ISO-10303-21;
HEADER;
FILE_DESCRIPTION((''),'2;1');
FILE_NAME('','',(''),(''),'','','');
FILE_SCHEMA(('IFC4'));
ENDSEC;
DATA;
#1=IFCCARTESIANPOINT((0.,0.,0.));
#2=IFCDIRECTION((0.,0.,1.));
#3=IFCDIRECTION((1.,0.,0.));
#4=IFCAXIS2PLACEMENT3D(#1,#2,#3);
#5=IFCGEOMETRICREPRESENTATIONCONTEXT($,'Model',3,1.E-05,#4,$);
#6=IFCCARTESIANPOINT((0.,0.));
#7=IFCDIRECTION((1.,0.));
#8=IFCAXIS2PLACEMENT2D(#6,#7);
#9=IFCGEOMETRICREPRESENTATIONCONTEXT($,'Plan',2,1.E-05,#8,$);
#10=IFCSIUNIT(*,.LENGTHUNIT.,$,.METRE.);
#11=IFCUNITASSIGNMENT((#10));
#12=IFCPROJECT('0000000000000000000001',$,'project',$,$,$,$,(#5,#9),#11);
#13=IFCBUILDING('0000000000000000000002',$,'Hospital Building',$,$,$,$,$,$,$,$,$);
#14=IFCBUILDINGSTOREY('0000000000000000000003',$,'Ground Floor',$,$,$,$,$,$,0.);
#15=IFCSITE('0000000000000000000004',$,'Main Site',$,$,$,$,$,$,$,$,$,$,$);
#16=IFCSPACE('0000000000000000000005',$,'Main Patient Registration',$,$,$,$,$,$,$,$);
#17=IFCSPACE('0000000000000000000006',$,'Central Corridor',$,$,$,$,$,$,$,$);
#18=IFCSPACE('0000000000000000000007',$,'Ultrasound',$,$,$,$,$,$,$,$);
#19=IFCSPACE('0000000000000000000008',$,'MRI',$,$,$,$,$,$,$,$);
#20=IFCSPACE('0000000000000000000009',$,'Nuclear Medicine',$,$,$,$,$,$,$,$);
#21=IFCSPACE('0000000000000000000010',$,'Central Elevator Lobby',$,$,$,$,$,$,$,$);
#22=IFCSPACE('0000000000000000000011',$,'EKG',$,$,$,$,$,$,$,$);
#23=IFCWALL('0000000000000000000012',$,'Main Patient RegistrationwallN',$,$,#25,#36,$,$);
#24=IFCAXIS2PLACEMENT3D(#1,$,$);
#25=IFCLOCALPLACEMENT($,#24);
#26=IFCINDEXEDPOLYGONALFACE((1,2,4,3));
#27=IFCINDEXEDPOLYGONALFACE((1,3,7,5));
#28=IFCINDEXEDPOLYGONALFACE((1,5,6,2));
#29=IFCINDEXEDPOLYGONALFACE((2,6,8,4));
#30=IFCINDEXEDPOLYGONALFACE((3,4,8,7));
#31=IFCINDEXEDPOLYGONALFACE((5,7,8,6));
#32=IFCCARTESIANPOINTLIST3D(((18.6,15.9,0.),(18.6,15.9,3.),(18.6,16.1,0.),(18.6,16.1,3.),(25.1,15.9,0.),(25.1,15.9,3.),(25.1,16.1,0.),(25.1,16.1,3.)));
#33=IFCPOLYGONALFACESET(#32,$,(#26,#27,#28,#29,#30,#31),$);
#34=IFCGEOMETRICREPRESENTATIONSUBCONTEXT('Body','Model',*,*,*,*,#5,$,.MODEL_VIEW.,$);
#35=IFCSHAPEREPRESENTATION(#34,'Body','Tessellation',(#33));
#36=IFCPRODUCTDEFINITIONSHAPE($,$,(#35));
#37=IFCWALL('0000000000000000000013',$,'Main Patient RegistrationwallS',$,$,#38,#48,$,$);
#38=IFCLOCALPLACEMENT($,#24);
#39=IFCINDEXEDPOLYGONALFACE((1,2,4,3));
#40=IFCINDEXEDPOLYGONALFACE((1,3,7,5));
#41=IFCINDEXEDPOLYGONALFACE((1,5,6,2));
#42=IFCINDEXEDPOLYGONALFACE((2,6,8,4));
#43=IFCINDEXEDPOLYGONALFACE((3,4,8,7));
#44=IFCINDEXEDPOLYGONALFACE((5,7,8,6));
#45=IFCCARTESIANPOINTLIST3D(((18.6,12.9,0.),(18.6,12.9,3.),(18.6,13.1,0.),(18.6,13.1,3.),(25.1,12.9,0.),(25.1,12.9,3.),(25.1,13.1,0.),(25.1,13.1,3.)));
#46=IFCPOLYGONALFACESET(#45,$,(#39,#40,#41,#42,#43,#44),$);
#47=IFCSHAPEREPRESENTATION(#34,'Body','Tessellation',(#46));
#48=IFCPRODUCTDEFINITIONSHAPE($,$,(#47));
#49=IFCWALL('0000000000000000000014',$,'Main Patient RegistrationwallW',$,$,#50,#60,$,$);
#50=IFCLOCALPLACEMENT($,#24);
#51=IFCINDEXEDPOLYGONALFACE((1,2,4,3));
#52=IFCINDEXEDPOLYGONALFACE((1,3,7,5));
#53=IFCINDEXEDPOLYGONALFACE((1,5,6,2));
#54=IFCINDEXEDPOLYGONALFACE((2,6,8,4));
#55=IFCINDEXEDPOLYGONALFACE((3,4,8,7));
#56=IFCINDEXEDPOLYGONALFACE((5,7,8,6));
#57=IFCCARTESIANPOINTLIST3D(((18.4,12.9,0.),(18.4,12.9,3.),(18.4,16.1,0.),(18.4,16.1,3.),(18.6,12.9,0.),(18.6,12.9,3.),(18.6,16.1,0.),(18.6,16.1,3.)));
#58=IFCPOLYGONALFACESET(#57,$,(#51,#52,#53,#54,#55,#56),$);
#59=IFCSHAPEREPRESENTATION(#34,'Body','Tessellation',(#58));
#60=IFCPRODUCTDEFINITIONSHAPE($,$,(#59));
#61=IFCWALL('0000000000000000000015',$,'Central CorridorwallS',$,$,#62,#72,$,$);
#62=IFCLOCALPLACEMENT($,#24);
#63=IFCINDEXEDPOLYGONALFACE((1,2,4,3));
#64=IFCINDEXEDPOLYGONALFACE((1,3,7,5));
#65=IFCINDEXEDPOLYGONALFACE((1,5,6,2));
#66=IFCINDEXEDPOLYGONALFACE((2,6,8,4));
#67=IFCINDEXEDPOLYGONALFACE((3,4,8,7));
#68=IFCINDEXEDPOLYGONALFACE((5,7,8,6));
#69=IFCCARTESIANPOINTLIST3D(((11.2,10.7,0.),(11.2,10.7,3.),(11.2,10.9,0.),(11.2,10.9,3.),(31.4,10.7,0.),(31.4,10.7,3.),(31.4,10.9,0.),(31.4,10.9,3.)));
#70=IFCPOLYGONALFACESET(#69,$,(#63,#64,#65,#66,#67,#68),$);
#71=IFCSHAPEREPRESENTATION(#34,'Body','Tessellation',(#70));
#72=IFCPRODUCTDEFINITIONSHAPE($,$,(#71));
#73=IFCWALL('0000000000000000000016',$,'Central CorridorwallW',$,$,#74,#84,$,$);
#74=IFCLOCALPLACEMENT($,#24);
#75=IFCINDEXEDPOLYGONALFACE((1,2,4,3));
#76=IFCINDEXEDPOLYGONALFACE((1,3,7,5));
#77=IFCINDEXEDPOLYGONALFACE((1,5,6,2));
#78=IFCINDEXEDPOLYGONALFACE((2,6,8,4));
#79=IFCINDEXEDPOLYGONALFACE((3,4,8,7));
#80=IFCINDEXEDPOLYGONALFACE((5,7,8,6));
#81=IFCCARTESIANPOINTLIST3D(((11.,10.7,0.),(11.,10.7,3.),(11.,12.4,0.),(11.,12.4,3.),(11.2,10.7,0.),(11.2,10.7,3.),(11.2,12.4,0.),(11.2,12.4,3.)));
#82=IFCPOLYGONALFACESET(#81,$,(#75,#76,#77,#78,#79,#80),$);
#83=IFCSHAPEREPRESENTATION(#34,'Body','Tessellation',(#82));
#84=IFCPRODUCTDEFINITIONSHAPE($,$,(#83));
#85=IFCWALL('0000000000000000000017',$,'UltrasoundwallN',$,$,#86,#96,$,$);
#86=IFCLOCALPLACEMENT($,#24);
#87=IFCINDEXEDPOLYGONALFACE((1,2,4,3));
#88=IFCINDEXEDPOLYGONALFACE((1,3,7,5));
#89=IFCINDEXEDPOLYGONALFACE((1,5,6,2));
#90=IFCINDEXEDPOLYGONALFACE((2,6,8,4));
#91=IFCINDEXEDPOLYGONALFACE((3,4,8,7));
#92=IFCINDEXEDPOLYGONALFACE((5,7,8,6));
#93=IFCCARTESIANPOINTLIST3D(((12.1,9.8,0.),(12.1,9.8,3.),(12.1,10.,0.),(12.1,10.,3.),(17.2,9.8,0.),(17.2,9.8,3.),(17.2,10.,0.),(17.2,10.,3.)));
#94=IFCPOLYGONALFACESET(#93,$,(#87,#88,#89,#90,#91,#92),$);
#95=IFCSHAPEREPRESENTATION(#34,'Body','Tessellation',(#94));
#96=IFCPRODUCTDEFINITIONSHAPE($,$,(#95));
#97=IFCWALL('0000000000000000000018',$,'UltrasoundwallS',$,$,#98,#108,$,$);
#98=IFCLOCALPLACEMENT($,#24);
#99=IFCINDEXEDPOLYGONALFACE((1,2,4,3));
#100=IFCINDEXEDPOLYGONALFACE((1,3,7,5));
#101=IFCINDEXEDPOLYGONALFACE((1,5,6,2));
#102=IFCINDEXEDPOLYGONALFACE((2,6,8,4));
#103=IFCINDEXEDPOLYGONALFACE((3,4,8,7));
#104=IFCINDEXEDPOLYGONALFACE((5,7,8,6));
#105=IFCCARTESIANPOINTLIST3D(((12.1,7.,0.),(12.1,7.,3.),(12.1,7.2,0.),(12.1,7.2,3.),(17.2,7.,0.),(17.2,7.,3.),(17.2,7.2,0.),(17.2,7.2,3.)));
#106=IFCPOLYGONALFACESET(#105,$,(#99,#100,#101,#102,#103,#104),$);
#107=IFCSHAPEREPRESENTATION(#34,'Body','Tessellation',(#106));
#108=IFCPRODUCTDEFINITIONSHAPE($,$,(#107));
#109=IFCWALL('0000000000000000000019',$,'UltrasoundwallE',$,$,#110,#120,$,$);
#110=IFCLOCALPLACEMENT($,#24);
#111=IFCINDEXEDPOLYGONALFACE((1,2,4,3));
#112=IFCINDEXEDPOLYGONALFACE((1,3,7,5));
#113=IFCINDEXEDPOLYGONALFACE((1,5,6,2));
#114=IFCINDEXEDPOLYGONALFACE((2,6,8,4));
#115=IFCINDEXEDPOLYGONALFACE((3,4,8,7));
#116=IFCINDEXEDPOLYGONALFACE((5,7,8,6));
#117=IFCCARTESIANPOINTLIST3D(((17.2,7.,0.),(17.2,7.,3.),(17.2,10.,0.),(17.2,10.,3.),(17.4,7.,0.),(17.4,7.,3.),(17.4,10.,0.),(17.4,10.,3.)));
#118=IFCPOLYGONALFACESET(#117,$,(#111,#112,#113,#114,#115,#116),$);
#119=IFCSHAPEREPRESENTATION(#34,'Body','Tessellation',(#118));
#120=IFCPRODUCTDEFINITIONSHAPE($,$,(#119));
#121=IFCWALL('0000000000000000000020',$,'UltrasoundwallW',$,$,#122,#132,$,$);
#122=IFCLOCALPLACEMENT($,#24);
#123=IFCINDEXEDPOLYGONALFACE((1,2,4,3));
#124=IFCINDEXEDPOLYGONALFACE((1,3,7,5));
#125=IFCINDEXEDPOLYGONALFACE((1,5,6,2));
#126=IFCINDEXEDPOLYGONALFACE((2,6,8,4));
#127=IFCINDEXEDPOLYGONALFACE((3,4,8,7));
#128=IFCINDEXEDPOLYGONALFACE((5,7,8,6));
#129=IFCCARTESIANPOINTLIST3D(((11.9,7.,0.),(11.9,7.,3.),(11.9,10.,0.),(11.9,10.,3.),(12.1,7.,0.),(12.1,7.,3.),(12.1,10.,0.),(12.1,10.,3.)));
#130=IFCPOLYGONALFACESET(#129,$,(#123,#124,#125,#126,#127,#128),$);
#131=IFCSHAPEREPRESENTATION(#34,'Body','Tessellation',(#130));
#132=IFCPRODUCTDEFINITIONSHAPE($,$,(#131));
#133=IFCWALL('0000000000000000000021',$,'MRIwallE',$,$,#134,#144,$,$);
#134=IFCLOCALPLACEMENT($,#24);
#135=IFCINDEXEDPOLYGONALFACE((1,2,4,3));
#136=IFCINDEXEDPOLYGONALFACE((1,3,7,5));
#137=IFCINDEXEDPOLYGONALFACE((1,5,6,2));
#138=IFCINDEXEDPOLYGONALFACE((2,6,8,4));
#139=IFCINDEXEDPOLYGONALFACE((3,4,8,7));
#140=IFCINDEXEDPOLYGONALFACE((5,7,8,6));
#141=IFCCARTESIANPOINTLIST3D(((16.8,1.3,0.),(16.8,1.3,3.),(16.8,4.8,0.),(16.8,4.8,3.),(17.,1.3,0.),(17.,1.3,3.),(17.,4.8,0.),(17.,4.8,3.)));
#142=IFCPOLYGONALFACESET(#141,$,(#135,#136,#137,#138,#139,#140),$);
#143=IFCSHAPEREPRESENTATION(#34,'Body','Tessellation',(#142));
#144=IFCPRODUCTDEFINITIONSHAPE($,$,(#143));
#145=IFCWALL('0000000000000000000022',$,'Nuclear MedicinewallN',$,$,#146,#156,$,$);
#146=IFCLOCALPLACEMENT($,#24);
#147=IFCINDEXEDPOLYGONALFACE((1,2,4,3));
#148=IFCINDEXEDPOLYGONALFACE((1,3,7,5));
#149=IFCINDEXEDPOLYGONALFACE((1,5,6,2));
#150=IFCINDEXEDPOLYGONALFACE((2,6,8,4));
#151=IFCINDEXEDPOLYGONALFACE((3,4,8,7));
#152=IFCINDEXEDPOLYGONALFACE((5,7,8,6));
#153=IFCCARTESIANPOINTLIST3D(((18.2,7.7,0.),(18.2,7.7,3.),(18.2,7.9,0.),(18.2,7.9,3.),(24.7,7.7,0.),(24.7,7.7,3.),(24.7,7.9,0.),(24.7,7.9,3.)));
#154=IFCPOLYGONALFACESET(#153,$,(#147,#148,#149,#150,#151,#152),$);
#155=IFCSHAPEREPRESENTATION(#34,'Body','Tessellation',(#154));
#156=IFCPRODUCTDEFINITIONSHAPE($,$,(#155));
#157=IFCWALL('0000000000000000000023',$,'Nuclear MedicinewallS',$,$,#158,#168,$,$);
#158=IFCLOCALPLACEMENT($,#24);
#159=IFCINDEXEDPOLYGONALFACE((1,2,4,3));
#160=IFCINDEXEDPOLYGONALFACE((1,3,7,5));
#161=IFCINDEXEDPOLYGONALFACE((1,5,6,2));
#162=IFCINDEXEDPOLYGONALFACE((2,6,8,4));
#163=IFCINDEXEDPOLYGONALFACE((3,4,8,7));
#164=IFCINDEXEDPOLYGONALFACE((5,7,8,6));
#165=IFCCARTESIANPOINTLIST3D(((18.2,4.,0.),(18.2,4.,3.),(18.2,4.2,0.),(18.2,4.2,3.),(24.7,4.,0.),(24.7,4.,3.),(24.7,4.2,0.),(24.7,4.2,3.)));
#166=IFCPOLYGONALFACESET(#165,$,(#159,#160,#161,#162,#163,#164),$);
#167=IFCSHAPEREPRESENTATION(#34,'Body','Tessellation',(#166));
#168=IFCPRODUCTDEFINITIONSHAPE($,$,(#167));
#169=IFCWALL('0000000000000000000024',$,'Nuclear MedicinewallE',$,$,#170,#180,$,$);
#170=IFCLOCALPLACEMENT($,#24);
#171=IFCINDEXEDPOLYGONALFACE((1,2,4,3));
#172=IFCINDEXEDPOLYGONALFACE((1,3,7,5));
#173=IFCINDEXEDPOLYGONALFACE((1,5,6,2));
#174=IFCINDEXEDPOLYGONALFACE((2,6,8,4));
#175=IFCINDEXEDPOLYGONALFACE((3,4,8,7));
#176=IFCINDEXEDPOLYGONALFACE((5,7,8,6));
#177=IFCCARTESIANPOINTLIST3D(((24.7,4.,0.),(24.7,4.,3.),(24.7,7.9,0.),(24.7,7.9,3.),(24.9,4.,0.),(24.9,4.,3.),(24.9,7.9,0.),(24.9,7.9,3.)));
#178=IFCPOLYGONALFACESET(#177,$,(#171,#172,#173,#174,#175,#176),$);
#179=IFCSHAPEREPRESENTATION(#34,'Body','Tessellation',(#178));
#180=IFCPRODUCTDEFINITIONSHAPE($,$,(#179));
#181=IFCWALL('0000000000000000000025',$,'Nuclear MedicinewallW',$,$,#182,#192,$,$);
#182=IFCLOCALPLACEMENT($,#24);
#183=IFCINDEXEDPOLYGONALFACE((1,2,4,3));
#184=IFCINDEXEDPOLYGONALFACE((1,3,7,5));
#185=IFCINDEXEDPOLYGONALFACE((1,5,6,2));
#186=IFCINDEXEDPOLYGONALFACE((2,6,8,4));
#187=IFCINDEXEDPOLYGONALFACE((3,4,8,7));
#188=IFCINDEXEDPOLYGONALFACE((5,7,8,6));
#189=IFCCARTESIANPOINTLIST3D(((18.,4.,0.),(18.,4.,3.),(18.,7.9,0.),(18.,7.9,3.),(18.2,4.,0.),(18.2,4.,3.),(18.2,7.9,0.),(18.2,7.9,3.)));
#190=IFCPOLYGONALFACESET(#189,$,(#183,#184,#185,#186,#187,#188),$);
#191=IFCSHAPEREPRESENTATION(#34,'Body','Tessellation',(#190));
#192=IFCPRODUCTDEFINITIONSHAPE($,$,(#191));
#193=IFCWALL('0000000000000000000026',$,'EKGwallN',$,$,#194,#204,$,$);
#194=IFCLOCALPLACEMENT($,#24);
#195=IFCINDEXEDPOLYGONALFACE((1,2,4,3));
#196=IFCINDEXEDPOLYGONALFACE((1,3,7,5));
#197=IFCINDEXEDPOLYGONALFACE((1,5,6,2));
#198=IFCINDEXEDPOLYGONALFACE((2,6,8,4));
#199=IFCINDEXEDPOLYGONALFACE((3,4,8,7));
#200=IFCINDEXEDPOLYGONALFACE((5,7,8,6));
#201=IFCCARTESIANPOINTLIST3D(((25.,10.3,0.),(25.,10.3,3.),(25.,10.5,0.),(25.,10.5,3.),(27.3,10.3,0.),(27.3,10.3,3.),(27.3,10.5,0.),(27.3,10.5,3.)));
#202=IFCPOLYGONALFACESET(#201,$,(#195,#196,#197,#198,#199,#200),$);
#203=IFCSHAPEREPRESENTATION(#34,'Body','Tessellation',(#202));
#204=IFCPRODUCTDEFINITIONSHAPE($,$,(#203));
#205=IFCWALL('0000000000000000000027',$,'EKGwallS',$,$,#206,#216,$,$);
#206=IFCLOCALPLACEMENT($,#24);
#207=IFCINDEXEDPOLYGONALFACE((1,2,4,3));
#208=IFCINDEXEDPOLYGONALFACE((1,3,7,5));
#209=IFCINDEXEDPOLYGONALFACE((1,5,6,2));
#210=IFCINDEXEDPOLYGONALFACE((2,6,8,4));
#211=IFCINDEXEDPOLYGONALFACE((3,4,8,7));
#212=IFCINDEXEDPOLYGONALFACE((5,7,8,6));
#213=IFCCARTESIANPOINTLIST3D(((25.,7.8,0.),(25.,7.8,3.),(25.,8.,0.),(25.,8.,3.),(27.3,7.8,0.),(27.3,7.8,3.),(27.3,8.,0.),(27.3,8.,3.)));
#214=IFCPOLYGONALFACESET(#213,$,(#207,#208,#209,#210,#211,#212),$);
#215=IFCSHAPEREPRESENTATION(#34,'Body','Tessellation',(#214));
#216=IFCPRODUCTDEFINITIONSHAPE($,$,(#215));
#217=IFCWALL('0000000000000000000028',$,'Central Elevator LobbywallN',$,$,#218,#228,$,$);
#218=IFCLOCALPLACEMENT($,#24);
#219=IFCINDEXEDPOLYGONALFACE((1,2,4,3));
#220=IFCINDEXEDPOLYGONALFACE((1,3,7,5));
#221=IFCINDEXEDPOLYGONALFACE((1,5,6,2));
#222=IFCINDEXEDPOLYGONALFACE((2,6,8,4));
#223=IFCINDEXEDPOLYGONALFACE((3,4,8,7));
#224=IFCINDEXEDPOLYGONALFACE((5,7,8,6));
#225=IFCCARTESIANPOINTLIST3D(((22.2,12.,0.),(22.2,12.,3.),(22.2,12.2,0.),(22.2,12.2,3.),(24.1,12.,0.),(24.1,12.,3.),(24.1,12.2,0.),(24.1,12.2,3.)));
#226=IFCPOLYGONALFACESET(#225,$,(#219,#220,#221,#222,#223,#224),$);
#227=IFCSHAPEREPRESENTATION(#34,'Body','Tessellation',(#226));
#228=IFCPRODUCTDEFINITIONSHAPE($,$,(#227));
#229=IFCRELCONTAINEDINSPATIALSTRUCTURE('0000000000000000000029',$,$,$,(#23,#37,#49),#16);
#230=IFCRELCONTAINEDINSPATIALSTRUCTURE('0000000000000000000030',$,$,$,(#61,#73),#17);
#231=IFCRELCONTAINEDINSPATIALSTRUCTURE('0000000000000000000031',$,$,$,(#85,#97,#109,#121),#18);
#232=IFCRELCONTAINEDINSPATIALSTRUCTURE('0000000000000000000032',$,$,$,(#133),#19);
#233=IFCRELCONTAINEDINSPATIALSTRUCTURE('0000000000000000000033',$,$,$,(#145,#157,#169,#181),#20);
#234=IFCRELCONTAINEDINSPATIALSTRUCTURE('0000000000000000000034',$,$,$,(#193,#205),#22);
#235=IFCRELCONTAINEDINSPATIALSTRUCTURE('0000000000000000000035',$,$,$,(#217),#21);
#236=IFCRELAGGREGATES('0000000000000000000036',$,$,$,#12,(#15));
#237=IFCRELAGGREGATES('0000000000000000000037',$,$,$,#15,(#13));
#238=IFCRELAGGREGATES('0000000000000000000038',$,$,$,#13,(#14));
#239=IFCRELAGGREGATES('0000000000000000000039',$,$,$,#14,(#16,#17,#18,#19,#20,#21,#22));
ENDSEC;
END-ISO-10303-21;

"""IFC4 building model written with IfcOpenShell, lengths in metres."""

from ifc_helpers import new_model, si_unit, frame, origin_with_axes, origin_2d_with_axis, place, context, subcontext, project, spatial, indexed_curve, outline, extrude, element, save


model = new_model("IFC4")

# Units and contexts
model_context = context("Model", 3, precision=1e-05, world=origin_with_axes())
plan_context = context("Plan", 2, precision=1e-05, world=origin_2d_with_axis())
body_context = subcontext(model_context, "Body", "Model", "MODEL_VIEW")
ifc_project = project(units=[si_unit("LENGTHUNIT", "METRE")], contexts=[model_context, plan_context])

# Site, building, storey
site = spatial("IfcSite", under=ifc_project, Name="Main Site")
building = spatial("IfcBuilding", under=site, Name="Hospital Building")
storey = spatial("IfcBuildingStorey", under=building, Name="Ground Floor", Elevation=0.0)

# Shared definitions
space_1 = spatial("IfcSpace", under=storey, Name="Main Patient Registration")

# Shared definitions
space_2 = spatial("IfcSpace", under=storey, Name="Central Corridor")

# Shared definitions
space_3 = spatial("IfcSpace", under=storey, Name="Ultrasound")

# Shared definitions
space_4 = spatial("IfcSpace", under=storey, Name="MRI")

# Shared definitions
space_5 = spatial("IfcSpace", under=storey, Name="Nuclear Medicine")

# Shared definitions
space_6 = spatial("IfcSpace", under=storey, Name="Central Elevator Lobby")

# Walls
for number, where, z_axis, x_axis, name in (
    (1, (18.6, 15.9, 0.0), (0.0, 0.0, 1.0), (1.0, 0.0, 0.0), "Main Patient RegistrationwallN"),
    (2, (18.6, 12.9, 0.0), (0.0, 0.0, 1.0), (1.0, 0.0, 0.0), "Main Patient RegistrationwallS"),
):
    element("IfcWall", number, at=place(None, frame(where, z_axis=z_axis, x_axis=x_axis)), inside=space_1, Name=name, context=body_context, shape_type="SweptSolid", body=[
        extrude(outline(indexed_curve([(0.0, 0.0), (0.0, 0.2), (6.5, 0.2), (6.5, 0.0), (0.0, 0.0)], self_intersect=False)), origin_with_axes(), (0.0, 0.0, 1.0), 3.0),
    ])
wall_1_placement = place(None, frame((18.6, 12.9, 0.0), z_axis=(0.0, 0.0, 1.0), x_axis=(0.0, 1.0, 0.0)))
element("IfcWall", 3, at=wall_1_placement, inside=space_1, Name="Main Patient RegistrationwallW", context=body_context, shape_type="SweptSolid", body=[
    extrude(outline(indexed_curve([(0.0, 0.0), (0.0, 0.2), (3.2, 0.2), (3.2, 0.0), (0.0, 0.0)], self_intersect=False)), origin_with_axes(), (0.0, 0.0, 1.0), 3.0),
])
wall_2_placement = place(None, frame((11.2, 10.7, 0.0), z_axis=(0.0, 0.0, 1.0), x_axis=(1.0, 0.0, 0.0)))
element("IfcWall", 4, at=wall_2_placement, inside=space_2, Name="Central CorridorwallS", context=body_context, shape_type="SweptSolid", body=[
    extrude(outline(indexed_curve([(0.0, 0.0), (0.0, 0.2), (20.2, 0.2), (20.2, 0.0), (0.0, 0.0)], self_intersect=False)), origin_with_axes(), (0.0, 0.0, 1.0), 3.0),
])
wall_3_placement = place(None, frame((11.2, 10.7, 0.0), z_axis=(0.0, 0.0, 1.0), x_axis=(0.0, 1.0, 0.0)))
element("IfcWall", 5, at=wall_3_placement, inside=space_2, Name="Central CorridorwallW", context=body_context, shape_type="SweptSolid", body=[
    extrude(outline(indexed_curve([(0.0, 0.0), (0.0, 0.2), (1.7, 0.2), (1.7, 0.0), (0.0, 0.0)], self_intersect=False)), origin_with_axes(), (0.0, 0.0, 1.0), 3.0),
])
for number, where, z_axis, x_axis, name in (
    (6, (12.1, 9.8, 0.0), (0.0, 0.0, 1.0), (1.0, 0.0, 0.0), "UltrasoundwallN"),
    (7, (12.1, 7.0, 0.0), (0.0, 0.0, 1.0), (1.0, 0.0, 0.0), "UltrasoundwallS"),
):
    element("IfcWall", number, at=place(None, frame(where, z_axis=z_axis, x_axis=x_axis)), inside=space_3, Name=name, context=body_context, shape_type="SweptSolid", body=[
        extrude(outline(indexed_curve([(0.0, 0.0), (0.0, 0.2), (5.1, 0.2), (5.1, 0.0), (0.0, 0.0)], self_intersect=False)), origin_with_axes(), (0.0, 0.0, 1.0), 3.0),
    ])
for number, where, z_axis, x_axis, name in (
    (8, (17.4, 7.0, 0.0), (0.0, 0.0, 1.0), (0.0, 1.0, 0.0), "UltrasoundwallE"),
    (9, (12.1, 7.0, 0.0), (0.0, 0.0, 1.0), (0.0, 1.0, 0.0), "UltrasoundwallW"),
):
    element("IfcWall", number, at=place(None, frame(where, z_axis=z_axis, x_axis=x_axis)), inside=space_3, Name=name, context=body_context, shape_type="SweptSolid", body=[
        extrude(outline(indexed_curve([(0.0, 0.0), (0.0, 0.2), (3.0, 0.2), (3.0, 0.0), (0.0, 0.0)], self_intersect=False)), origin_with_axes(), (0.0, 0.0, 1.0), 3.0),
    ])
wall_4_placement = place(None, frame((17.0, 1.3, 0.0), z_axis=(0.0, 0.0, 1.0), x_axis=(0.0, 1.0, 0.0)))
element("IfcWall", 10, at=wall_4_placement, inside=space_4, Name="MRIwallE", context=body_context, shape_type="SweptSolid", body=[
    extrude(outline(indexed_curve([(0.0, 0.0), (0.0, 0.2), (3.5, 0.2), (3.5, 0.0), (0.0, 0.0)], self_intersect=False)), origin_with_axes(), (0.0, 0.0, 1.0), 3.0),
])
for number, where, z_axis, x_axis, name in (
    (11, (18.2, 7.7, 0.0), (0.0, 0.0, 1.0), (1.0, 0.0, 0.0), "Nuclear MedicinewallN"),
    (12, (18.2, 4.0, 0.0), (0.0, 0.0, 1.0), (1.0, 0.0, 0.0), "Nuclear MedicinewallS"),
):
    element("IfcWall", number, at=place(None, frame(where, z_axis=z_axis, x_axis=x_axis)), inside=space_5, Name=name, context=body_context, shape_type="SweptSolid", body=[
        extrude(outline(indexed_curve([(0.0, 0.0), (0.0, 0.2), (6.5, 0.2), (6.5, 0.0), (0.0, 0.0)], self_intersect=False)), origin_with_axes(), (0.0, 0.0, 1.0), 3.0),
    ])
for number, where, z_axis, x_axis, name in (
    (13, (24.9, 4.0, 0.0), (0.0, 0.0, 1.0), (0.0, 1.0, 0.0), "Nuclear MedicinewallE"),
    (14, (18.2, 4.0, 0.0), (0.0, 0.0, 1.0), (0.0, 1.0, 0.0), "Nuclear MedicinewallW"),
):
    element("IfcWall", number, at=place(None, frame(where, z_axis=z_axis, x_axis=x_axis)), inside=space_5, Name=name, context=body_context, shape_type="SweptSolid", body=[
        extrude(outline(indexed_curve([(0.0, 0.0), (0.0, 0.2), (3.9, 0.2), (3.9, 0.0), (0.0, 0.0)], self_intersect=False)), origin_with_axes(), (0.0, 0.0, 1.0), 3.0),
    ])

# Shared definitions
space_7 = spatial("IfcSpace", under=storey, Name="EKG")

# Walls
for number, where, z_axis, x_axis, name in (
    (15, (25.0, 10.3, 0.0), (0.0, 0.0, 1.0), (1.0, 0.0, 0.0), "EKGwallN"),
    (16, (25.0, 7.8, 0.0), (0.0, 0.0, 1.0), (1.0, 0.0, 0.0), "EKGwallS"),
):
    element("IfcWall", number, at=place(None, frame(where, z_axis=z_axis, x_axis=x_axis)), inside=space_7, Name=name, context=body_context, shape_type="SweptSolid", body=[
        extrude(outline(indexed_curve([(0.0, 0.0), (0.0, 0.2), (2.3, 0.2), (2.3, 0.0), (0.0, 0.0)], self_intersect=False)), origin_with_axes(), (0.0, 0.0, 1.0), 3.0),
    ])
for number, where, z_axis, x_axis, name in (
    (17, (22.2, 12.0, 0.0), (0.0, 0.0, 1.0), (1.0, 0.0, 0.0), "Central Elevator LobbywallN"),
):
    element("IfcWall", number, at=place(None, frame(where, z_axis=z_axis, x_axis=x_axis)), inside=space_6, Name=name, context=body_context, shape_type="SweptSolid", body=[
        extrude(outline(indexed_curve([(0.0, 0.0), (0.0, 0.2), (1.9, 0.2), (1.9, 0.0), (0.0, 0.0)], self_intersect=False)), origin_with_axes(), (0.0, 0.0, 1.0), 3.0),
    ])

save(model, "model.ifc")
